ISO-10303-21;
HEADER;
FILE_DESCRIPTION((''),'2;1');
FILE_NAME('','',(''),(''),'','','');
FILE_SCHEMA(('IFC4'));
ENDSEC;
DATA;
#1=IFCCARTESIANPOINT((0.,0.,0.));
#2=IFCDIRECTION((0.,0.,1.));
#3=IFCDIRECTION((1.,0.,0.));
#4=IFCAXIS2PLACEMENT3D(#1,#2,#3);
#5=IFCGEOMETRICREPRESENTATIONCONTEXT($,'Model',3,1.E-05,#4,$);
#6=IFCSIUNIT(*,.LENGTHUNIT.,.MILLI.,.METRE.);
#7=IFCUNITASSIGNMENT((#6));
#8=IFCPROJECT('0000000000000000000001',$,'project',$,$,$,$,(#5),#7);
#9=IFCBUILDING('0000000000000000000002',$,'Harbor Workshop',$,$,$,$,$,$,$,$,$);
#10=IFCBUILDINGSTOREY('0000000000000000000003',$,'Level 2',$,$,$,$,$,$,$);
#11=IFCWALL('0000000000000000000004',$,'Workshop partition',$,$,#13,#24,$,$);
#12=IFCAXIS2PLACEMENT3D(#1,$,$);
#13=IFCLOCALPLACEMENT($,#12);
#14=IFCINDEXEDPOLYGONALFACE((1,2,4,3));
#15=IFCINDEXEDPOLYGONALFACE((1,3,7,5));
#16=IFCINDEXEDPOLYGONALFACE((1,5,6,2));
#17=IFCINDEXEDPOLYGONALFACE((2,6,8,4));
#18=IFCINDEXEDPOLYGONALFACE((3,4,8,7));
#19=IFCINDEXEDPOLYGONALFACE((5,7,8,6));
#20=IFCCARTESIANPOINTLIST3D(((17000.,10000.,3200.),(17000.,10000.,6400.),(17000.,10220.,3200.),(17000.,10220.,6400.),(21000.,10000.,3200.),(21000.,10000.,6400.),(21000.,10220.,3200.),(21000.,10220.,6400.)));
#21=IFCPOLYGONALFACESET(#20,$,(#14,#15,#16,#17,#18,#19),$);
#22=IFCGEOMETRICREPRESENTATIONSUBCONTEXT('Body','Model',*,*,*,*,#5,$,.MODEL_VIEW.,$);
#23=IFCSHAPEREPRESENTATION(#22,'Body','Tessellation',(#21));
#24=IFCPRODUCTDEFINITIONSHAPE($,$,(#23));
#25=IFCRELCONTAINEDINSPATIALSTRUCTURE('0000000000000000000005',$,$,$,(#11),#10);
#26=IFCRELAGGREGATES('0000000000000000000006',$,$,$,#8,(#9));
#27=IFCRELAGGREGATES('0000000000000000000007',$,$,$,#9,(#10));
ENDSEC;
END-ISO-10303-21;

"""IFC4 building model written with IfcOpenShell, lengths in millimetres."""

from ifc_helpers import new_model, si_unit, frame, origin_with_axes, place, context, subcontext, project, spatial, indexed_curve, outline, extrude, element, save


model = new_model("IFC4")

# Units and contexts
model_context = context("Model", 3, precision=1e-05, world=origin_with_axes())
body_context = subcontext(model_context, "Body", "Model", "MODEL_VIEW")
ifc_project = project(units=[si_unit("LENGTHUNIT", "METRE", prefix="MILLI")], contexts=[model_context])

# Building, storey
building = spatial("IfcBuilding", under=ifc_project, Name="Harbor Workshop")
storey = spatial("IfcBuildingStorey", under=building, Name="Level 2")

# Wall
wall_1_placement = place(None, frame((17000.0, 10000.0, 3200.0), z_axis=(0.0, 0.0, 1.0), x_axis=(1.0, 0.0, 0.0)))
element("IfcWall", 1, at=wall_1_placement, inside=storey, Name="Workshop partition", context=body_context, shape_type="SweptSolid", body=[
    extrude(outline(indexed_curve([(0.0, 0.0), (0.0, 220.0), (4000.0, 220.0), (4000.0, 0.0), (0.0, 0.0)], self_intersect=False)), origin_with_axes(), (0.0, 0.0, 1.0), 3200.0),
])

save(model, "model.ifc")
